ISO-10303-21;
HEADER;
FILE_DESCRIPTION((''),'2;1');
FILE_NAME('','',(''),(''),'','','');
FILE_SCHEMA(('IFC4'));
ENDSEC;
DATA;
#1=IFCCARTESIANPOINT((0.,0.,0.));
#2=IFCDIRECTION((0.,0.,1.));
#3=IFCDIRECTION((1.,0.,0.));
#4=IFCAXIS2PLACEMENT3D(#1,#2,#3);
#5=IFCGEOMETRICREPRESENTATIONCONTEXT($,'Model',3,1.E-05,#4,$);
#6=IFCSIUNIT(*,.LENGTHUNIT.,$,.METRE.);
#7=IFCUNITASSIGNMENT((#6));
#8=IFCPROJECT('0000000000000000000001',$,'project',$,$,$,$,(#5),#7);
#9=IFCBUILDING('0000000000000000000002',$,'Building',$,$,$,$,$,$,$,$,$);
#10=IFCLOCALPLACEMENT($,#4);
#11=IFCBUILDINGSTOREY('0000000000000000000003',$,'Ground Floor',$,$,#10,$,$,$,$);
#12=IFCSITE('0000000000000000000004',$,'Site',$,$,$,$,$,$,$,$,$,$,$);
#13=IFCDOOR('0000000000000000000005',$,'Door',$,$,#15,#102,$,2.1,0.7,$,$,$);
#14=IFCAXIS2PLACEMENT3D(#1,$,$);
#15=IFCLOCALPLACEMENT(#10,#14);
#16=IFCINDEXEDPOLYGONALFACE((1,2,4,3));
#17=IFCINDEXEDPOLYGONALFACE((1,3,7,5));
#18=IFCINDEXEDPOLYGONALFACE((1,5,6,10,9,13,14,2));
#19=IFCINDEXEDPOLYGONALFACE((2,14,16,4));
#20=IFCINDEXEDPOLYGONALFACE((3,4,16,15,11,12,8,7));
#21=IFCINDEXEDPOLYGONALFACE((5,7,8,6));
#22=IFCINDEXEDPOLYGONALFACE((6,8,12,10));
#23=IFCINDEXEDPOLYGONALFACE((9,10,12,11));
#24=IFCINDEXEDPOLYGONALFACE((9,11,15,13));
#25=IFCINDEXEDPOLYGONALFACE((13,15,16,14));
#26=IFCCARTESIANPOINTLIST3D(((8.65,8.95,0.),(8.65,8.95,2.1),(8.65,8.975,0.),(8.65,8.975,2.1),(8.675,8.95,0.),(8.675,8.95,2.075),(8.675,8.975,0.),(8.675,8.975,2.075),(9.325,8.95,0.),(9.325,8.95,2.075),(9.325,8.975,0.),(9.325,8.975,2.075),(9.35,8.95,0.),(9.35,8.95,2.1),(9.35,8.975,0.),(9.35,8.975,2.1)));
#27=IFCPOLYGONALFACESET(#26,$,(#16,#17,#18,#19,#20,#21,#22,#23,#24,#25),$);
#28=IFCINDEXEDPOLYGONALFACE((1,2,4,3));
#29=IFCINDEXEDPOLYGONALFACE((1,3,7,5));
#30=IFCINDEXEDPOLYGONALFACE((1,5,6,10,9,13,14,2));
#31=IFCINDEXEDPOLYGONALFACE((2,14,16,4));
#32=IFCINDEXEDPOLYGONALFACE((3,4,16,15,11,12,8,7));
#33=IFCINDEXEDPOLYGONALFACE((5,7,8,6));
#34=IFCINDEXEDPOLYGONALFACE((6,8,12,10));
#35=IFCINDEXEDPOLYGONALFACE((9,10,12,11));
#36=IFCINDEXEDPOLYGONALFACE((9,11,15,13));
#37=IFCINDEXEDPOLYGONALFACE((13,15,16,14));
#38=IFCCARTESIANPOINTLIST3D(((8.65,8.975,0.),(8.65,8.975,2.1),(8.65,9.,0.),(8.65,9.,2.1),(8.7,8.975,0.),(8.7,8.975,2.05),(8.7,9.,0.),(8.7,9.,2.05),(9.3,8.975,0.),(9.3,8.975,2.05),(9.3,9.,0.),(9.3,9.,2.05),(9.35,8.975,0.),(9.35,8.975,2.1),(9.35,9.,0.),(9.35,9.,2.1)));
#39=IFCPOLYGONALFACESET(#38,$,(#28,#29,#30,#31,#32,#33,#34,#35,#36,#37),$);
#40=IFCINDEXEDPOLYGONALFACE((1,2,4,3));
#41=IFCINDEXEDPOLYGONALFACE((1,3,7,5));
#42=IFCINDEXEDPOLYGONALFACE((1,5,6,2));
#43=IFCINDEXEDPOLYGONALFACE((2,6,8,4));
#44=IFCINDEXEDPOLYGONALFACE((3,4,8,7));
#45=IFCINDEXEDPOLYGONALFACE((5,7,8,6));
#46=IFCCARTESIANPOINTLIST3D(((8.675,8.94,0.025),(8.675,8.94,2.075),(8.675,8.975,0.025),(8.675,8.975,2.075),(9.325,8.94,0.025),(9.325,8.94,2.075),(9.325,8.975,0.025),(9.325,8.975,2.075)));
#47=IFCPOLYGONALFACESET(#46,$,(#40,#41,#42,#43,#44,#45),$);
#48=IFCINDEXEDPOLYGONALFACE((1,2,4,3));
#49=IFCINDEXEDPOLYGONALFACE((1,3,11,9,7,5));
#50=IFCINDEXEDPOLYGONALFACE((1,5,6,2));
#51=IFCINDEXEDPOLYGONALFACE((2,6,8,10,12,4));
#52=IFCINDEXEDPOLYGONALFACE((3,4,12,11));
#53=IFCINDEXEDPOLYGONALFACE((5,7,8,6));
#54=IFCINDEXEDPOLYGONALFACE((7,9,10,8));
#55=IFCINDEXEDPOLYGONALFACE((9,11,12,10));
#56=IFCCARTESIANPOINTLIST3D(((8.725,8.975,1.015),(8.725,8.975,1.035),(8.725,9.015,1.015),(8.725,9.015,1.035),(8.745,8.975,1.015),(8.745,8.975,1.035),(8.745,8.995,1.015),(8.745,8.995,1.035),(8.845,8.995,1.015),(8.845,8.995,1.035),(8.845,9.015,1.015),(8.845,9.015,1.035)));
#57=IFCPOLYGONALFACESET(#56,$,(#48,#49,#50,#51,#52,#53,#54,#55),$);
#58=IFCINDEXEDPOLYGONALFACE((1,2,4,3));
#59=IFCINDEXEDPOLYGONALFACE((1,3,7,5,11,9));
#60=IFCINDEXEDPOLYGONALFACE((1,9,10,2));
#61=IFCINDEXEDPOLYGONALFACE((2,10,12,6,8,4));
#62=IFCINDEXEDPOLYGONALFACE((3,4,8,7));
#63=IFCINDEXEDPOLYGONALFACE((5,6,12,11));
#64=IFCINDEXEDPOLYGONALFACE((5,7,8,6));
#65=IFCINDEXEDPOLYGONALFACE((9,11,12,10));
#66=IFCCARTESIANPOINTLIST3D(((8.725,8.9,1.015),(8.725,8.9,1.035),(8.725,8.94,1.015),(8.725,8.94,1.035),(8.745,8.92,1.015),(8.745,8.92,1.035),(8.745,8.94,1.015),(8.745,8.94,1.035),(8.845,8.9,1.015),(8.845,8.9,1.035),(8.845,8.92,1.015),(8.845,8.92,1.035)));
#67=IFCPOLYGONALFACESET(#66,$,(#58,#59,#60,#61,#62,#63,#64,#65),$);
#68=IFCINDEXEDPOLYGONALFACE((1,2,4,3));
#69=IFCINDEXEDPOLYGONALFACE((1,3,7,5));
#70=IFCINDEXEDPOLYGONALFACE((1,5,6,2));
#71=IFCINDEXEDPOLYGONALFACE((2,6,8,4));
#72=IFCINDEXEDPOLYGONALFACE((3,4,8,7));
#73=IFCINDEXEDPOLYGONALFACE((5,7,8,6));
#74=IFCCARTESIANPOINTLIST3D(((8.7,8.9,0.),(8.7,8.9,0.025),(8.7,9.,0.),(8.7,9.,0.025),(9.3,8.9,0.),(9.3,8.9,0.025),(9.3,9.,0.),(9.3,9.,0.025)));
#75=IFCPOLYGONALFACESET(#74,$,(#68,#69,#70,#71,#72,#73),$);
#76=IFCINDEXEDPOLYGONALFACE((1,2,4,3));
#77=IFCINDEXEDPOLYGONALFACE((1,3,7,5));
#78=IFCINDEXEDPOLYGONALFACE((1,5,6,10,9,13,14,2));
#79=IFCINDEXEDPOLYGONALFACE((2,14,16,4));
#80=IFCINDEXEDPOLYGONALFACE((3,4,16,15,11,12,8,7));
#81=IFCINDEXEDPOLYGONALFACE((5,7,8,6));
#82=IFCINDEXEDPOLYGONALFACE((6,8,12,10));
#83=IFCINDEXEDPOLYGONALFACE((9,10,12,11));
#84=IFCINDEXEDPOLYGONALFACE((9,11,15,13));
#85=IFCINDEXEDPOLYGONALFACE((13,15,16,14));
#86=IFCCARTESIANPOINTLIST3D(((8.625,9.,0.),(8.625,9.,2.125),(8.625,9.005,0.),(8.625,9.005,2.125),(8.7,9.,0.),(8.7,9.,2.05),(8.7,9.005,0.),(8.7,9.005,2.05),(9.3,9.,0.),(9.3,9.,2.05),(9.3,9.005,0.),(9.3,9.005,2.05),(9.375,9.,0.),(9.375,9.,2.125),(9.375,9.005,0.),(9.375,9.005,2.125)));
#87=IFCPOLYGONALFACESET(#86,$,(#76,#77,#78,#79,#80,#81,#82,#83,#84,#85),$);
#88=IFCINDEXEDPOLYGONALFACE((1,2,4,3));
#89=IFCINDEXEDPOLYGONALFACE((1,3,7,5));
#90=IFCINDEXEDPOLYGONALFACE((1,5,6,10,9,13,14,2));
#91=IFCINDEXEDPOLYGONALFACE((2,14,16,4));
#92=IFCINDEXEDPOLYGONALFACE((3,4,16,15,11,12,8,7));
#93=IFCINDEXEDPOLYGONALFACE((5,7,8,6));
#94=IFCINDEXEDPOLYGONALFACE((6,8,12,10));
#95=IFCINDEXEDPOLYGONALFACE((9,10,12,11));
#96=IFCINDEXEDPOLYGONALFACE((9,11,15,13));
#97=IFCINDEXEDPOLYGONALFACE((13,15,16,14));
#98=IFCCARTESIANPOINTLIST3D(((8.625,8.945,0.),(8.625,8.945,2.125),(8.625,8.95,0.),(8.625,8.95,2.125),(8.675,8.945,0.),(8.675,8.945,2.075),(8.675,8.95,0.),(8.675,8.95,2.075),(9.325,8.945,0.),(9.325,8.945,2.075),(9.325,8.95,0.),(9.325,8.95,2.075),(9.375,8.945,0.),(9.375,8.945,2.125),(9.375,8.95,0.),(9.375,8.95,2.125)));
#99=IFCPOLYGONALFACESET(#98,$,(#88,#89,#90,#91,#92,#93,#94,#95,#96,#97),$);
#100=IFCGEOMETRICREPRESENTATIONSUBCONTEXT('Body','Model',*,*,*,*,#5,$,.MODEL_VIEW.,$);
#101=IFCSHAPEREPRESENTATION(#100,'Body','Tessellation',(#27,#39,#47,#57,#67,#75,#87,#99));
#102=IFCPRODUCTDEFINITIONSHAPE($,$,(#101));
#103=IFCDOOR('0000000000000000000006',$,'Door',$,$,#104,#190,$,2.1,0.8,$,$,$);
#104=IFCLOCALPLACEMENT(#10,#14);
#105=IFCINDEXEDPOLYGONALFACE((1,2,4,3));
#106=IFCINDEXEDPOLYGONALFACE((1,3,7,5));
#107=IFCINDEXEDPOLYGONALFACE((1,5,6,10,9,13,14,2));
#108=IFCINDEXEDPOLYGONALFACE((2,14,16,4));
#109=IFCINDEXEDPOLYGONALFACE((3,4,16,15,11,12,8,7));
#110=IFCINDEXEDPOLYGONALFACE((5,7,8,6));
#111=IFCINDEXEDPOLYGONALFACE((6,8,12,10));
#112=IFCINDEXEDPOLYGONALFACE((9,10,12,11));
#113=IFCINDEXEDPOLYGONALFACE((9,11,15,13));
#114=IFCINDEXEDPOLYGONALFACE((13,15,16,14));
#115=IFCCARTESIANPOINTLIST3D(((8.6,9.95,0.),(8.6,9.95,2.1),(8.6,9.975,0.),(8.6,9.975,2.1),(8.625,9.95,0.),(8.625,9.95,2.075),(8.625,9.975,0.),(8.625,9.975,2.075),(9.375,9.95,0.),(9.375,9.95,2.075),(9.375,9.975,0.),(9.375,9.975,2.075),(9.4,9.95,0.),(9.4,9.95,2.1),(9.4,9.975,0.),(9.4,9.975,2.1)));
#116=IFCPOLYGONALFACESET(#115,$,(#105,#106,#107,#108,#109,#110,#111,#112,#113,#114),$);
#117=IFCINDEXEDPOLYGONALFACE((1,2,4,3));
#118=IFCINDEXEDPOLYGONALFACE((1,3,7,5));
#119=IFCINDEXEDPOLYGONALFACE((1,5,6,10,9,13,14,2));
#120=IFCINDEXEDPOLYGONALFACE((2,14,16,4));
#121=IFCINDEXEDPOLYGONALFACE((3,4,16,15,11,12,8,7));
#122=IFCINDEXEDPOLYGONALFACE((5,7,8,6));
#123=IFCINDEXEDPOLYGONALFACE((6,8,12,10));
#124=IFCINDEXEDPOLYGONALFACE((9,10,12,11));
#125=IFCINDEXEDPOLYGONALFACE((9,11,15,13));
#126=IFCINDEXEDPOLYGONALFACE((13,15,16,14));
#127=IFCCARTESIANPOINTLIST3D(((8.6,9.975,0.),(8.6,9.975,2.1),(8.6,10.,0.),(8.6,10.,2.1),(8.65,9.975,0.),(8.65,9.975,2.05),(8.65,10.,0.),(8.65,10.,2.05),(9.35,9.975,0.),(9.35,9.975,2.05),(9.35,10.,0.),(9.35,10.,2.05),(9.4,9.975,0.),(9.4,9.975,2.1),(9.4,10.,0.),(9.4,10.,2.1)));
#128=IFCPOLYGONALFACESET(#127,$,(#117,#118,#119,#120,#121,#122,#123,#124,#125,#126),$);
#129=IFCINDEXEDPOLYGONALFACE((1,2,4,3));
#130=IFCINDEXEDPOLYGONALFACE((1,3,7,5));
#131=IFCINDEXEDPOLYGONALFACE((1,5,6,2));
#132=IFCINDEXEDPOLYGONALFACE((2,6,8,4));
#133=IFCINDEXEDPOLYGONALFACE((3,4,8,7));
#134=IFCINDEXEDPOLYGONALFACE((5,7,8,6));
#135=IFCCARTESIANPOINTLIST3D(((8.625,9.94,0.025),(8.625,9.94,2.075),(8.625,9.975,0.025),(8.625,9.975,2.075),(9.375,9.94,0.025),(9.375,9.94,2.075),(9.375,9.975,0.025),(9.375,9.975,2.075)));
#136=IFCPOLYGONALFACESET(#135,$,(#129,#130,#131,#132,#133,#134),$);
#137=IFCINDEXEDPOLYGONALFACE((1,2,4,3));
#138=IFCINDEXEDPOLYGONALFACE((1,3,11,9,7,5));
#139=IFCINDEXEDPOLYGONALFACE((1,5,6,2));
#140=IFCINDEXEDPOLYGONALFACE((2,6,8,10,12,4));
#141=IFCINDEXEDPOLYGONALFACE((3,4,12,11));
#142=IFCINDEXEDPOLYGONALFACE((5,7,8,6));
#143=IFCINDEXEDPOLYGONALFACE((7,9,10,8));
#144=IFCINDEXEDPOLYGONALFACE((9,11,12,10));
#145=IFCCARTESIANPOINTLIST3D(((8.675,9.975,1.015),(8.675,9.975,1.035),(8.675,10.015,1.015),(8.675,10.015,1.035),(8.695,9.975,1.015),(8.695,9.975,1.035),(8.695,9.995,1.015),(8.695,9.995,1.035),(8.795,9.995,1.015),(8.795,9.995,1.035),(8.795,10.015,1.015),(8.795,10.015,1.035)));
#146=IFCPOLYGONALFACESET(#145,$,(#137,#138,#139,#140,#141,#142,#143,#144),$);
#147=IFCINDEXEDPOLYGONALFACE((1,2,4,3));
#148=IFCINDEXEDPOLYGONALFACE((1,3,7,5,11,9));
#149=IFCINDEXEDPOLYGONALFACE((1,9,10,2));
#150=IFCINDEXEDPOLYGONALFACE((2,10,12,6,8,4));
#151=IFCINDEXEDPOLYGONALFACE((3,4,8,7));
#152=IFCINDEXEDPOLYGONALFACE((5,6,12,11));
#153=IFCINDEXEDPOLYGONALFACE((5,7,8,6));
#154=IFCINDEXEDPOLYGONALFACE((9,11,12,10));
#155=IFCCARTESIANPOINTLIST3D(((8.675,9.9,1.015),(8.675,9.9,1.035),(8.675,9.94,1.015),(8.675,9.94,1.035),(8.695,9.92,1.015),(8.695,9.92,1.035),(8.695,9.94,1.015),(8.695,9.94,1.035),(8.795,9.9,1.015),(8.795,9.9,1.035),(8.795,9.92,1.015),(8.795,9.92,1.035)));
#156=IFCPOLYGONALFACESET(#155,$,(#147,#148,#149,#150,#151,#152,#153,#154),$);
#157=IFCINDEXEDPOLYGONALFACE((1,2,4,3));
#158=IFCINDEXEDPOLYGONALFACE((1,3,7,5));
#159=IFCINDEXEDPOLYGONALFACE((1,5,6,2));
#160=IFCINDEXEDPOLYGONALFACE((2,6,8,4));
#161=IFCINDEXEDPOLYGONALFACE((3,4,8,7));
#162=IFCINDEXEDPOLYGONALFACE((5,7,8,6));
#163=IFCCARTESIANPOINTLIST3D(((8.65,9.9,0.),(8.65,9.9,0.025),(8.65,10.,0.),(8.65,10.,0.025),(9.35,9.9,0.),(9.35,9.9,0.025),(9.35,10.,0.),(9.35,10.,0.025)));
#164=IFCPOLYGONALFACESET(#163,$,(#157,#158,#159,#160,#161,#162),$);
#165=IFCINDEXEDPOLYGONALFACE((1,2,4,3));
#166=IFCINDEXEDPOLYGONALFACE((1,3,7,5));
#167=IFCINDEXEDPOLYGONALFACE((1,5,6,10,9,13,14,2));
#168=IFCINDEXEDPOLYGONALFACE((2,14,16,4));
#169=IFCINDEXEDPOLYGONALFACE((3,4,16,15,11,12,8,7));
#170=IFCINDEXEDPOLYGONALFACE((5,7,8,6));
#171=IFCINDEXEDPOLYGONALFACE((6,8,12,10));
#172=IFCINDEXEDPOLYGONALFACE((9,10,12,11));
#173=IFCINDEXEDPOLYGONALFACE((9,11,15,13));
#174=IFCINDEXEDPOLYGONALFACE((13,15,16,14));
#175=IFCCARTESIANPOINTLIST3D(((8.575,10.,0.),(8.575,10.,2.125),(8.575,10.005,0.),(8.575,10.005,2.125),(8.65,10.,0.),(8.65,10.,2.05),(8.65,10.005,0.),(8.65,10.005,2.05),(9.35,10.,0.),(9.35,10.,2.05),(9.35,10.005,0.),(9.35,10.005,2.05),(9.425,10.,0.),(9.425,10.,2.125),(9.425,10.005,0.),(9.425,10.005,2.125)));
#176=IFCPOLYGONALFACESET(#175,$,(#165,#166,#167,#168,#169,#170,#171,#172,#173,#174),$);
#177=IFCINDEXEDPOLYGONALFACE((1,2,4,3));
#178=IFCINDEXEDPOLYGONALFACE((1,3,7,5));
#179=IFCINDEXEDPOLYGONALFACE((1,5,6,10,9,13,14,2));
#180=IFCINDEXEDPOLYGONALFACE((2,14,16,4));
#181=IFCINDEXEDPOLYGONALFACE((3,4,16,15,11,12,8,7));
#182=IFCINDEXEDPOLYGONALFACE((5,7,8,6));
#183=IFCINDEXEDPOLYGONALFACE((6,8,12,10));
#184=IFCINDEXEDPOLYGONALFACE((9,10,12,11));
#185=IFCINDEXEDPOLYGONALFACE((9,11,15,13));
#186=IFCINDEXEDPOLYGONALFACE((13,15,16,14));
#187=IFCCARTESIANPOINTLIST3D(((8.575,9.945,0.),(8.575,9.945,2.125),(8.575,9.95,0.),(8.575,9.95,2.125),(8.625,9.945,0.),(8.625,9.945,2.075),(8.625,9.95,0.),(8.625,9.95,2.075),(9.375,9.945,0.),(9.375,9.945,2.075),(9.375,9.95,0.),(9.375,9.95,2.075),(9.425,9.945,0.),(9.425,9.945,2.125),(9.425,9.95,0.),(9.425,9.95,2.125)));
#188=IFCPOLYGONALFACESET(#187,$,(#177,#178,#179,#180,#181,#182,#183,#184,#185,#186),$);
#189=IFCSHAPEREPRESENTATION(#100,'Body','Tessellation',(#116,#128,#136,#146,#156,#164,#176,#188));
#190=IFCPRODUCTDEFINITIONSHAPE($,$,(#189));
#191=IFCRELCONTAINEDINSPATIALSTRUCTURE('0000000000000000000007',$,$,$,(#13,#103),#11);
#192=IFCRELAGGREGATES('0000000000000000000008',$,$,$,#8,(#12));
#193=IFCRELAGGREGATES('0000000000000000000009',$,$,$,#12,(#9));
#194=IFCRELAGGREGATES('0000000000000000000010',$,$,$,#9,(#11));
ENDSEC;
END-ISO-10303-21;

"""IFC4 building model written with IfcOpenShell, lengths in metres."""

from ifc_helpers import new_model, si_unit, frame, origin_with_axes, place, context, subcontext, project, spatial, line, indexed_curve, outline, extrude, element, save


model = new_model("IFC4")

# Units and contexts
model_context = context("Model", 3, precision=1e-05, world=origin_with_axes())
body_context = subcontext(model_context, "Body", "Model", "MODEL_VIEW")
ifc_project = project(units=[si_unit("LENGTHUNIT", "METRE")], contexts=[model_context])

# Site, building, storey
site = spatial("IfcSite", under=ifc_project, Name="Site")
building = spatial("IfcBuilding", under=site, Name="Building")
storey_placement = place(None, origin_with_axes())
storey = spatial("IfcBuildingStorey", under=building, at=storey_placement, Name="Ground Floor")

# Doors
door_1_placement = place(storey_placement, frame((9.35, 9.0, 0.0), z_axis=(0.0, 0.0, 1.0), x_axis=(-1.0, 0.0, 0.0)))
element("IfcDoor", 1, at=door_1_placement, inside=storey, Name="Door", OverallHeight=2.1, OverallWidth=0.7, context=body_context, shape_type="SweptSolid", body=[
    extrude(outline(indexed_curve([(0.0, 0.0), (0.0, 2.1), (0.7, 2.1), (0.7, 0.0), (0.675, 0.0), (0.675, 2.075), (0.025, 2.075), (0.025, 0.0)], segments=[line(1, 2, 3, 4, 5, 6, 7, 8, 1)])), frame((0.0, 0.025, 0.0), z_axis=(0.0, -1.0, 0.0), x_axis=(1.0, 0.0, 0.0)), (0.0, 0.0, -1.0), 0.025),
    extrude(outline(indexed_curve([(0.0, 0.0), (0.0, 2.1), (0.7, 2.1), (0.7, 0.0), (0.65, 0.0), (0.65, 2.05), (0.05, 2.05), (0.05, 0.0)], segments=[line(1, 2, 3, 4, 5, 6, 7, 8, 1)])), frame((0.0, 0.0, 0.0), z_axis=(0.0, -1.0, 0.0), x_axis=(1.0, 0.0, 0.0)), (0.0, 0.0, -1.0), 0.025),
    extrude(outline(indexed_curve([(0.0, 0.0), (0.65, 0.0), (0.65, 0.035), (0.0, 0.035)], segments=[line(1, 2, 3, 4, 1)])), frame((0.025, 0.025, 0.025), z_axis=(0.0, 0.0, 1.0), x_axis=(1.0, 0.0, 0.0)), (0.0, 0.0, 1.0), 2.05),
    extrude(outline(indexed_curve([(0.0, 0.0), (0.0, -0.04), (-0.12, -0.04), (-0.12, -0.02), (-0.02, -0.02), (-0.02, 0.0)], segments=[line(1, 2, 3, 4, 5, 6, 1)])), frame((0.625, 0.025, 1.015), z_axis=(0.0, 0.0, 1.0), x_axis=(1.0, 0.0, 0.0)), (0.0, 0.0, 1.0), 0.02),
    extrude(outline(indexed_curve([(0.0, 0.0), (0.0, 0.04), (-0.12, 0.04), (-0.12, 0.02), (-0.02, 0.02), (-0.02, 0.0)], segments=[line(1, 2, 3, 4, 5, 6, 1)])), frame((0.625, 0.06, 1.015), z_axis=(0.0, 0.0, 1.0), x_axis=(1.0, 0.0, 0.0)), (0.0, 0.0, 1.0), 0.02),
    extrude(outline(indexed_curve([(0.0, 0.0), (0.6, 0.0), (0.6, 0.1), (0.0, 0.1)], segments=[line(1, 2, 3, 4, 1)])), frame((0.05, 0.0, 0.0), z_axis=(0.0, 0.0, 1.0), x_axis=(1.0, 0.0, 0.0)), (0.0, 0.0, 1.0), 0.025),
    extrude(outline(indexed_curve([(0.0, 0.0), (0.0, 2.125), (0.75, 2.125), (0.75, 0.0), (0.675, 0.0), (0.675, 2.05), (0.075, 2.05), (0.075, 0.0)], segments=[line(1, 2, 3, 4, 5, 6, 7, 8, 1)])), frame((-0.025, -0.005, 0.0), z_axis=(0.0, -1.0, 0.0), x_axis=(1.0, 0.0, 0.0)), (0.0, 0.0, -1.0), 0.005),
    extrude(outline(indexed_curve([(0.0, 0.0), (0.0, 2.125), (0.75, 2.125), (0.75, 0.0), (0.7, 0.0), (0.7, 2.075), (0.05, 2.075), (0.05, 0.0)], segments=[line(1, 2, 3, 4, 5, 6, 7, 8, 1)])), frame((-0.025, 0.05, 0.0), z_axis=(0.0, -1.0, 0.0), x_axis=(1.0, 0.0, 0.0)), (0.0, 0.0, -1.0), 0.005),
])
door_2_placement = place(storey_placement, frame((9.4, 10.0, 0.0), z_axis=(0.0, 0.0, 1.0), x_axis=(-1.0, 0.0, 0.0)))
element("IfcDoor", 2, at=door_2_placement, inside=storey, Name="Door", OverallHeight=2.1, OverallWidth=0.8, context=body_context, shape_type="SweptSolid", body=[
    extrude(outline(indexed_curve([(0.0, 0.0), (0.0, 2.1), (0.8, 2.1), (0.8, 0.0), (0.775, 0.0), (0.775, 2.075), (0.025, 2.075), (0.025, 0.0)], segments=[line(1, 2, 3, 4, 5, 6, 7, 8, 1)])), frame((0.0, 0.025, 0.0), z_axis=(0.0, -1.0, 0.0), x_axis=(1.0, 0.0, 0.0)), (0.0, 0.0, -1.0), 0.025),
    extrude(outline(indexed_curve([(0.0, 0.0), (0.0, 2.1), (0.8, 2.1), (0.8, 0.0), (0.75, 0.0), (0.75, 2.05), (0.05, 2.05), (0.05, 0.0)], segments=[line(1, 2, 3, 4, 5, 6, 7, 8, 1)])), frame((0.0, 0.0, 0.0), z_axis=(0.0, -1.0, 0.0), x_axis=(1.0, 0.0, 0.0)), (0.0, 0.0, -1.0), 0.025),
    extrude(outline(indexed_curve([(0.0, 0.0), (0.75, 0.0), (0.75, 0.035), (0.0, 0.035)], segments=[line(1, 2, 3, 4, 1)])), frame((0.025, 0.025, 0.025), z_axis=(0.0, 0.0, 1.0), x_axis=(1.0, 0.0, 0.0)), (0.0, 0.0, 1.0), 2.05),
    extrude(outline(indexed_curve([(0.0, 0.0), (0.0, -0.04), (-0.12, -0.04), (-0.12, -0.02), (-0.02, -0.02), (-0.02, 0.0)], segments=[line(1, 2, 3, 4, 5, 6, 1)])), frame((0.725, 0.025, 1.015), z_axis=(0.0, 0.0, 1.0), x_axis=(1.0, 0.0, 0.0)), (0.0, 0.0, 1.0), 0.02),
    extrude(outline(indexed_curve([(0.0, 0.0), (0.0, 0.04), (-0.12, 0.04), (-0.12, 0.02), (-0.02, 0.02), (-0.02, 0.0)], segments=[line(1, 2, 3, 4, 5, 6, 1)])), frame((0.725, 0.06, 1.015), z_axis=(0.0, 0.0, 1.0), x_axis=(1.0, 0.0, 0.0)), (0.0, 0.0, 1.0), 0.02),
    extrude(outline(indexed_curve([(0.0, 0.0), (0.7, 0.0), (0.7, 0.1), (0.0, 0.1)], segments=[line(1, 2, 3, 4, 1)])), frame((0.05, 0.0, 0.0), z_axis=(0.0, 0.0, 1.0), x_axis=(1.0, 0.0, 0.0)), (0.0, 0.0, 1.0), 0.025),
    extrude(outline(indexed_curve([(0.0, 0.0), (0.0, 2.125), (0.85, 2.125), (0.85, 0.0), (0.775, 0.0), (0.775, 2.05), (0.075, 2.05), (0.075, 0.0)], segments=[line(1, 2, 3, 4, 5, 6, 7, 8, 1)])), frame((-0.025, -0.005, 0.0), z_axis=(0.0, -1.0, 0.0), x_axis=(1.0, 0.0, 0.0)), (0.0, 0.0, -1.0), 0.005),
    extrude(outline(indexed_curve([(0.0, 0.0), (0.0, 2.125), (0.85, 2.125), (0.85, 0.0), (0.8, 0.0), (0.8, 2.075), (0.05, 2.075), (0.05, 0.0)], segments=[line(1, 2, 3, 4, 5, 6, 7, 8, 1)])), frame((-0.025, 0.05, 0.0), z_axis=(0.0, -1.0, 0.0), x_axis=(1.0, 0.0, 0.0)), (0.0, 0.0, -1.0), 0.005),
])

save(model, "model.ifc")
